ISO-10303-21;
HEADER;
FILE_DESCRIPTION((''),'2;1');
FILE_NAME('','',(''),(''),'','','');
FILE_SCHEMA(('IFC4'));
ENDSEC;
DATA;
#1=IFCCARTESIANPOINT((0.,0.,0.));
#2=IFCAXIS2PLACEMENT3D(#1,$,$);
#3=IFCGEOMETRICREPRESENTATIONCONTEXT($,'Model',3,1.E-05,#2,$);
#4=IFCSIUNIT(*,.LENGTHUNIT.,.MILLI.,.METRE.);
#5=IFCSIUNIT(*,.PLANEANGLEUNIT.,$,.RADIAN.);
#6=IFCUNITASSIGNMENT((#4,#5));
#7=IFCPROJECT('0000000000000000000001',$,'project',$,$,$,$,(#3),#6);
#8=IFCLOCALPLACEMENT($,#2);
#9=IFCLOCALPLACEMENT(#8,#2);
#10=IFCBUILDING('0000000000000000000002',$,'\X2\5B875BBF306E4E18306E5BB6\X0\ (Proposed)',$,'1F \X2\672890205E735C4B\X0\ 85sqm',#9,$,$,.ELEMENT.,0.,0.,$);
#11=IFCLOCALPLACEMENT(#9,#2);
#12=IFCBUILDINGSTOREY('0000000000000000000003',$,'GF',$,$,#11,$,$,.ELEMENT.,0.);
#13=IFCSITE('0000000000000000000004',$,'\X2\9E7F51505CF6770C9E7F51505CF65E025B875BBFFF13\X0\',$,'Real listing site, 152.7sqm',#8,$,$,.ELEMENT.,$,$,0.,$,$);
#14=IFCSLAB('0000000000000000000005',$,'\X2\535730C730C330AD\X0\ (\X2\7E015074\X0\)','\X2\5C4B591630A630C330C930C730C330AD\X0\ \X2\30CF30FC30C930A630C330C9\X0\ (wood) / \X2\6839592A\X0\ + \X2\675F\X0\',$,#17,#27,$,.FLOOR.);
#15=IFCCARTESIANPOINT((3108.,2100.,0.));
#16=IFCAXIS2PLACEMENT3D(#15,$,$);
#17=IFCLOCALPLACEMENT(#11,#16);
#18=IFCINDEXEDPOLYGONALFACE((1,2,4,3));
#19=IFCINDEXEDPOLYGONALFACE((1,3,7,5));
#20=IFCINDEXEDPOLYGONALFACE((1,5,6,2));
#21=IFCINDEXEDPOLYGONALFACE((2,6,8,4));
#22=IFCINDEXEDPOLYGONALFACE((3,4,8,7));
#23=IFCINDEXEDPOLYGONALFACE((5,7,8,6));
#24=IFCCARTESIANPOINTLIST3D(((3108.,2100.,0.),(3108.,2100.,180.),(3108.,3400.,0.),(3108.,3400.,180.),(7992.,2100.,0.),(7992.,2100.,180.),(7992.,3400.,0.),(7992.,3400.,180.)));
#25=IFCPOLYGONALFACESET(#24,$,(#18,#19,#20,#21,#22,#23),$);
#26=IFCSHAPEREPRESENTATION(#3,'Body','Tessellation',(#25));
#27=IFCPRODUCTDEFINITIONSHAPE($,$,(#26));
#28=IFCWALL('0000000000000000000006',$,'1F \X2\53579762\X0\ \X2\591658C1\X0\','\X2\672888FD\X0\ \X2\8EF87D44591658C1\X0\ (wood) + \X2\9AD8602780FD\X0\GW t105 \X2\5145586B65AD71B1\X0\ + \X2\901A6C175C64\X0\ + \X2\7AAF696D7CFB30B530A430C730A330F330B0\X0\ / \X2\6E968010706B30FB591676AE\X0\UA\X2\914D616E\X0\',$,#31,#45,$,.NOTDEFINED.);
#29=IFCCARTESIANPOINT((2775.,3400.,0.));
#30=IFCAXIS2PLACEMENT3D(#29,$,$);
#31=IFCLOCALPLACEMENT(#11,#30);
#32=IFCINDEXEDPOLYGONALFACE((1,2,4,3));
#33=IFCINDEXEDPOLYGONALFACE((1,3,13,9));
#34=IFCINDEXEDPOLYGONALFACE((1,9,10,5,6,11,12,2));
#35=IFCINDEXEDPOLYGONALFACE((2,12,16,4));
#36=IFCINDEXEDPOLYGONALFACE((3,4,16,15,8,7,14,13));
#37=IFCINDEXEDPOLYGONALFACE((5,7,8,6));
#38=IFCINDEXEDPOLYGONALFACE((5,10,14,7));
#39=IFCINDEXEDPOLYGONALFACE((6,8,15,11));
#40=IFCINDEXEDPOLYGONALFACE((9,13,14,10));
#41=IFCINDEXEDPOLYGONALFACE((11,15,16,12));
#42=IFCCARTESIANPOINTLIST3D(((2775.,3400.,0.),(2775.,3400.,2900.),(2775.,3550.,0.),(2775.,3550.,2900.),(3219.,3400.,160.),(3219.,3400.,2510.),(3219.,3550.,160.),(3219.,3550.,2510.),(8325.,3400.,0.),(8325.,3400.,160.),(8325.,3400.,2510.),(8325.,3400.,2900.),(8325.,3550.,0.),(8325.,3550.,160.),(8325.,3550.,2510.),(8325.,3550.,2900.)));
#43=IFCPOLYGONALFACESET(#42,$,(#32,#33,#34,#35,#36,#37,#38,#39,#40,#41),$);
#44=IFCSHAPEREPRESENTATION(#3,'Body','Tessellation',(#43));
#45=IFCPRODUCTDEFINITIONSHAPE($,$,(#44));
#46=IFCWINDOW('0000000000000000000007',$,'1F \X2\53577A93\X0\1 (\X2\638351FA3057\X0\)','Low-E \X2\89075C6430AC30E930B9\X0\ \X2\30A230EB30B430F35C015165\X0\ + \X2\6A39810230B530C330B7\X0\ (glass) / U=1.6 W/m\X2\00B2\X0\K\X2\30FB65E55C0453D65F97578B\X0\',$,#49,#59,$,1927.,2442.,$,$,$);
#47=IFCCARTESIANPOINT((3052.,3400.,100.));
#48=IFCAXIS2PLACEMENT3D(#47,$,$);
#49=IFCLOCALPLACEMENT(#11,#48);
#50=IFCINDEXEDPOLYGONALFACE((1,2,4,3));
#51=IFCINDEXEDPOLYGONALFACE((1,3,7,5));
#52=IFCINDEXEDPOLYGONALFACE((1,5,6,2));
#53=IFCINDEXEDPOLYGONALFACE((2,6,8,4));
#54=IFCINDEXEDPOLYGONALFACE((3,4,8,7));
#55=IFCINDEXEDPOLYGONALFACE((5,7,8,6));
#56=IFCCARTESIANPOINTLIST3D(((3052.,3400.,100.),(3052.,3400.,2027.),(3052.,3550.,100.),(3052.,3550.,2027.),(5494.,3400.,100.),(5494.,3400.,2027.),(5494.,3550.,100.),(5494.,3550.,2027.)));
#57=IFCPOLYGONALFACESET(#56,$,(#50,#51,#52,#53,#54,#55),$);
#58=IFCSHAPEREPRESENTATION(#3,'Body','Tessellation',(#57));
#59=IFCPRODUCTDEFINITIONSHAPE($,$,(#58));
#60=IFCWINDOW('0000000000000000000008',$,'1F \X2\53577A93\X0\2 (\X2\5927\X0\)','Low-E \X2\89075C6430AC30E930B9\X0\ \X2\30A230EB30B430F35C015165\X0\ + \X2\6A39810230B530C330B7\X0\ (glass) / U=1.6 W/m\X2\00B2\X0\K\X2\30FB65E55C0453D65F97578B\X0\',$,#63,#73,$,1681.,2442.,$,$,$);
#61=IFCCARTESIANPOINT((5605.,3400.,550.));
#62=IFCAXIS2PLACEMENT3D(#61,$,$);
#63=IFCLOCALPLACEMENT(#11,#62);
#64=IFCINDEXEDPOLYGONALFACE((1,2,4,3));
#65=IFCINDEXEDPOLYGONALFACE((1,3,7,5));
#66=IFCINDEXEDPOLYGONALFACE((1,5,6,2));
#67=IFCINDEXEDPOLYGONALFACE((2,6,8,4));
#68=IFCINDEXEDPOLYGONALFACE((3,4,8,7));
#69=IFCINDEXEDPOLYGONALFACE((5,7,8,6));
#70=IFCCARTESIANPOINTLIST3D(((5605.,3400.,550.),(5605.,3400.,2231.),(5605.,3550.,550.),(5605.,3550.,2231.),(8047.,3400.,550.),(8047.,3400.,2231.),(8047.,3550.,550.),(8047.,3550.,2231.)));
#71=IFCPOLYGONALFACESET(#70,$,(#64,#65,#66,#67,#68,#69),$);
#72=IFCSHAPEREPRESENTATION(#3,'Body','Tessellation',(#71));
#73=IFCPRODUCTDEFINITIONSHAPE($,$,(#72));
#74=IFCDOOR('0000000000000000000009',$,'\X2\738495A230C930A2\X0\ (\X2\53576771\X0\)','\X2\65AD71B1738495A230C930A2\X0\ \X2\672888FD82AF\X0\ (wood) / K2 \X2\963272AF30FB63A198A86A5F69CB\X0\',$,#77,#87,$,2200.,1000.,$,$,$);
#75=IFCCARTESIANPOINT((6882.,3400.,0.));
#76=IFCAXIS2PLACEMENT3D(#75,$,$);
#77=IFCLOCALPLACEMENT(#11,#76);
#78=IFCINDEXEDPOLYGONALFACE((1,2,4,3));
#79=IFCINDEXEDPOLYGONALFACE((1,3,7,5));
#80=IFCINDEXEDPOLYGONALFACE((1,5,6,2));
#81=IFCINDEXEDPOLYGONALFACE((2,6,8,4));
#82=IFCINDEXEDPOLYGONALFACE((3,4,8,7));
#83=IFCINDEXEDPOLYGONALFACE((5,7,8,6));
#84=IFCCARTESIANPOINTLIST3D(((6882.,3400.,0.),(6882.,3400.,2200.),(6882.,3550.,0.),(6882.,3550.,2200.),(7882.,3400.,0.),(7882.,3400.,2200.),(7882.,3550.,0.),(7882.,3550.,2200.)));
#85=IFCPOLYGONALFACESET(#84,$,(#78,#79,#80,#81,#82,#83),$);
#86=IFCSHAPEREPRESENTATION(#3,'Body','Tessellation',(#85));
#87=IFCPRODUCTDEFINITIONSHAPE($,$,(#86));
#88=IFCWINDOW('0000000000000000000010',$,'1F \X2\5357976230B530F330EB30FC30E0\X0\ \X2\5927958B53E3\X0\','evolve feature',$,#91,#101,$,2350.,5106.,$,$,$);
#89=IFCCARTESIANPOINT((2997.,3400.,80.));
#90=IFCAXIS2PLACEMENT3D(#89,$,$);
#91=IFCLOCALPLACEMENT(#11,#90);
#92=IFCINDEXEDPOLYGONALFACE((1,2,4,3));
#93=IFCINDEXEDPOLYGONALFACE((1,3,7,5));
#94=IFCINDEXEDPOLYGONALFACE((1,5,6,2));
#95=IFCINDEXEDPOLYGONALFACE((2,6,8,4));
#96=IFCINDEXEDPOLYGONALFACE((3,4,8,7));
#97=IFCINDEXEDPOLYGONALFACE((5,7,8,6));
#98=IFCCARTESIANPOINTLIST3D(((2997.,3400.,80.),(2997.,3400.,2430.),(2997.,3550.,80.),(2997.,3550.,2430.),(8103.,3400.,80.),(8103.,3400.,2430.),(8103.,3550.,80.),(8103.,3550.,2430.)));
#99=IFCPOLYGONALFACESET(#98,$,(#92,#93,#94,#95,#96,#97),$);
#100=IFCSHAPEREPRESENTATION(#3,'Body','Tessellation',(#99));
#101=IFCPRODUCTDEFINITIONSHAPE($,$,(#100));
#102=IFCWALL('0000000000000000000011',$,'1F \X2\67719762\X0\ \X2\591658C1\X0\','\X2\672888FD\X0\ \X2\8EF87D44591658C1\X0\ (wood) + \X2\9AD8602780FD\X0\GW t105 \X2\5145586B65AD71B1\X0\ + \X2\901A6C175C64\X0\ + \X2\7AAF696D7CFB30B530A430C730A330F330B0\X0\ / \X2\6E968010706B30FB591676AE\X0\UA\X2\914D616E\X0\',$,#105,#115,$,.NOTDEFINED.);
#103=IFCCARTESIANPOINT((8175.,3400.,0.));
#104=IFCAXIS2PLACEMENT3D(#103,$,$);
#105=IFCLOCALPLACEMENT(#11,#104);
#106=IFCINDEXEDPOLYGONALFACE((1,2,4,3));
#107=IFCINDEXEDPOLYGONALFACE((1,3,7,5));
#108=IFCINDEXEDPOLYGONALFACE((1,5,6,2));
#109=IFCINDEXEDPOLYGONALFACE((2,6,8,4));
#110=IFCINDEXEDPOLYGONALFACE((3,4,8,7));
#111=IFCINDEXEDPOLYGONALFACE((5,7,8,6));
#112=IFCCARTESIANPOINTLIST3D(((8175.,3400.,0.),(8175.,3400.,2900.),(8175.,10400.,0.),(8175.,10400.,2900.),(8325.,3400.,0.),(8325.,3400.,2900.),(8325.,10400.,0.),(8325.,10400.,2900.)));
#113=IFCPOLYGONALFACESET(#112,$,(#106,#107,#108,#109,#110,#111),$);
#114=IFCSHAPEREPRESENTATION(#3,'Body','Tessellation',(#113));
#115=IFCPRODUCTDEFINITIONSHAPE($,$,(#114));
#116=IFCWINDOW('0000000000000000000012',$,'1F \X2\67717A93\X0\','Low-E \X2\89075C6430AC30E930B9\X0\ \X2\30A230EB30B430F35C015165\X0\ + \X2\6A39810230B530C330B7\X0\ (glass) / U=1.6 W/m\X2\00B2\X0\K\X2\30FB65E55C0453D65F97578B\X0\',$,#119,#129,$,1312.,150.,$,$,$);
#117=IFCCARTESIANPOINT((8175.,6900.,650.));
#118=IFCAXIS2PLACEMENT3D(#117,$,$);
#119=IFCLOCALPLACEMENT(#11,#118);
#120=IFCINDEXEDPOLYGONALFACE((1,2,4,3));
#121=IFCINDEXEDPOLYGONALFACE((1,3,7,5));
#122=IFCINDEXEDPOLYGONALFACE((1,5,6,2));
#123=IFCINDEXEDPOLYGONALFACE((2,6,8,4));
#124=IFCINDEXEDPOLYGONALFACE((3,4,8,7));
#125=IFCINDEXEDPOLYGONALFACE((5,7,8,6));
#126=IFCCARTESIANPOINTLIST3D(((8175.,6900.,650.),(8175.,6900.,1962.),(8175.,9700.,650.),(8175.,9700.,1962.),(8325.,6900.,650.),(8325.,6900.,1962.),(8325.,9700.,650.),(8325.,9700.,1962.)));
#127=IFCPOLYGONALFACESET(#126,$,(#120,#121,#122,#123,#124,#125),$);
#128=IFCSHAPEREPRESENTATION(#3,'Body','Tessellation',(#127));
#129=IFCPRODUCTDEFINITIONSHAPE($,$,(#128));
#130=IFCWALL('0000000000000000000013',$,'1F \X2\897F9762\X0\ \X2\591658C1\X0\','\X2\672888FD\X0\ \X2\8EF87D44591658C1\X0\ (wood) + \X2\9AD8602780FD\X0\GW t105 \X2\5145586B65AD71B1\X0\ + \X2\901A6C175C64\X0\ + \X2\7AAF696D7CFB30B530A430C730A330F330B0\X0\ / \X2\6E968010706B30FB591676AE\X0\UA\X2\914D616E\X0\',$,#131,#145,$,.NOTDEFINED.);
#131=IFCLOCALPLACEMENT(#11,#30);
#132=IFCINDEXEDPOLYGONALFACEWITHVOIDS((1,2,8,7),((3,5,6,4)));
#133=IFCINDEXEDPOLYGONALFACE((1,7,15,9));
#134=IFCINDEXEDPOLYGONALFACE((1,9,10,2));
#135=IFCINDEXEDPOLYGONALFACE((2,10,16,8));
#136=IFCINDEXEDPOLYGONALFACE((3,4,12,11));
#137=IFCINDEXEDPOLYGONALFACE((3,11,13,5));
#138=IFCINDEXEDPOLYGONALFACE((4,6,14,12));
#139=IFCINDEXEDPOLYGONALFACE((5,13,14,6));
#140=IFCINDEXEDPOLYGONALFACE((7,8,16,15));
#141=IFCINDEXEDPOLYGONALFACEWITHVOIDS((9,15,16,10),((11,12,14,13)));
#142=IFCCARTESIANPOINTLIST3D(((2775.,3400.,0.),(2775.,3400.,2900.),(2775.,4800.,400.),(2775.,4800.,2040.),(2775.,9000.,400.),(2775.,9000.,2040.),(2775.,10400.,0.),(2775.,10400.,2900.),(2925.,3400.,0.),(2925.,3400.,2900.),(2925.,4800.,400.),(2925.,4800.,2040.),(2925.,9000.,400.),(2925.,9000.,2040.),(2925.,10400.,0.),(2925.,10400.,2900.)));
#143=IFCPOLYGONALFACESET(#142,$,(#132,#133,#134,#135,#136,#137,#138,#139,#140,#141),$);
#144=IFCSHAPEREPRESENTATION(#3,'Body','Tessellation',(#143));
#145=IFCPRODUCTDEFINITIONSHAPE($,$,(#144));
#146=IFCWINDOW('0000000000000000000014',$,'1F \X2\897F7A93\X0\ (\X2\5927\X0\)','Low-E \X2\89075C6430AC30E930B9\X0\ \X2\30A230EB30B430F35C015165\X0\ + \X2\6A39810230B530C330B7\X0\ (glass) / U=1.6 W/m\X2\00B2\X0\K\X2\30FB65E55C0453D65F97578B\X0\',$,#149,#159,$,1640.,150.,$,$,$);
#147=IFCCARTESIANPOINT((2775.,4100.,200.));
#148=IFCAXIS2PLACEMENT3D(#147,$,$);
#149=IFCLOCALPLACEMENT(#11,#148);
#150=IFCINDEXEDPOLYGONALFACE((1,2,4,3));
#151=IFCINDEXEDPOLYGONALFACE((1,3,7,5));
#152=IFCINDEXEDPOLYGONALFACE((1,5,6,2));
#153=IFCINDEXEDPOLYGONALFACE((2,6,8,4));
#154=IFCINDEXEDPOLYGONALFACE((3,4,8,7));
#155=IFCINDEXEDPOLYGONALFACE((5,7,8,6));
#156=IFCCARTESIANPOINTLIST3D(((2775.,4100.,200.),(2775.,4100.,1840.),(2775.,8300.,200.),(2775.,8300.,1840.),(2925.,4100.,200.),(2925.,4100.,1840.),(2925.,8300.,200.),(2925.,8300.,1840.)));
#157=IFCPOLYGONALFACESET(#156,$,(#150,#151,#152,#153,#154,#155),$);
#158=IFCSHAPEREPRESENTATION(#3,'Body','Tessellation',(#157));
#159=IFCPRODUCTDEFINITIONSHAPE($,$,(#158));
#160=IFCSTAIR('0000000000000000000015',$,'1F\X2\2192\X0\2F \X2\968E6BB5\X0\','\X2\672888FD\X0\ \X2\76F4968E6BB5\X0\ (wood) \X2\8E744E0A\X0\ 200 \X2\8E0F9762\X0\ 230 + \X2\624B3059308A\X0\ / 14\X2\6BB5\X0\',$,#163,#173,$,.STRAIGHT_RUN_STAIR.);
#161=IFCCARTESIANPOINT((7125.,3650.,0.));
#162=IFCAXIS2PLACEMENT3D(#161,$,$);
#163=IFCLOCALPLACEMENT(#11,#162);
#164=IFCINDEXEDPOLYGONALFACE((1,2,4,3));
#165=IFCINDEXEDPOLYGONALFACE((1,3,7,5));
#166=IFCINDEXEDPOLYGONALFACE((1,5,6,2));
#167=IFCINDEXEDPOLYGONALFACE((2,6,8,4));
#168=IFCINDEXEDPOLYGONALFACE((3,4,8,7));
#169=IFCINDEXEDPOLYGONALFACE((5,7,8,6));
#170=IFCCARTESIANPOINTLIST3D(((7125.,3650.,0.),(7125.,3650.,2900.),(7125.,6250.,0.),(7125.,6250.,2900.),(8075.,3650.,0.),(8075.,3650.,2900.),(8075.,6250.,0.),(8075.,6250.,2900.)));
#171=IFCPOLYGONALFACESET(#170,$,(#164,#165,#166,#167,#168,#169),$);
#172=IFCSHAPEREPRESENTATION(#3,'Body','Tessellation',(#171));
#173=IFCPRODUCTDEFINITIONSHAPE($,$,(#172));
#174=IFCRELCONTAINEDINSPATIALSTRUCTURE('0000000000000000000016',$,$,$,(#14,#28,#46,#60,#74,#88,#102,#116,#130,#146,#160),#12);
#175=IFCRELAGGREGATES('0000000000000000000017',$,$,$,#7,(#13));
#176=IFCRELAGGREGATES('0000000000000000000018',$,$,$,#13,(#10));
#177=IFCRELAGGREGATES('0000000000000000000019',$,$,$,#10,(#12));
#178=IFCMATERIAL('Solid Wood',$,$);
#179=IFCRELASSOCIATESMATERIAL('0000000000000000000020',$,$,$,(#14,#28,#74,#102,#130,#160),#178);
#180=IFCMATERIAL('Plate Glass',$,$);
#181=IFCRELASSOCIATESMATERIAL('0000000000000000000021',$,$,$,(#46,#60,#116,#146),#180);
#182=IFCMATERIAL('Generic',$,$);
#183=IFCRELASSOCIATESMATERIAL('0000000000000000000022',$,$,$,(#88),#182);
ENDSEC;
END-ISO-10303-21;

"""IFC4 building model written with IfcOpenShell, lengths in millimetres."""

from ifc_helpers import new_model, si_unit, frame, frame_2d, origin, place, context, project, spatial, rectangle, extrude, material, element, fill, save


model = new_model("IFC4")

# Units and contexts
model_context = context("Model", 3, precision=1e-05, world=origin())
ifc_project = project(units=[si_unit("LENGTHUNIT", "METRE", prefix="MILLI"), si_unit("PLANEANGLEUNIT", "RADIAN")], contexts=[model_context])

# Site, building, storey
site_placement = place(None, origin())
site = spatial("IfcSite", under=ifc_project, at=site_placement, Name="鹿児島県鹿児島市宇宿３", ObjectType="Real listing site, 152.7sqm", CompositionType="ELEMENT", RefElevation=0.0)
building_placement = place(site_placement, origin())
building = spatial("IfcBuilding", under=site, at=building_placement, Name="宇宿の丘の家 (Proposed)", ObjectType="1F 木造平屋 85sqm", CompositionType="ELEMENT", ElevationOfRefHeight=0.0, ElevationOfTerrain=0.0)
storey_placement = place(building_placement, origin())
storey = spatial("IfcBuildingStorey", under=building, at=storey_placement, Name="GF", CompositionType="ELEMENT", Elevation=0.0)

# Slab
ifc_material_1 = material(Name="Solid Wood")
slab_1_placement = place(storey_placement, frame((3108.0, 2100.0, 0.0)))
element("IfcSlab", 1, at=slab_1_placement, inside=storey, material=ifc_material_1, Name="南デッキ (縁側)", Description="屋外ウッドデッキ ハードウッド (wood) / 根太 + 束", PredefinedType="FLOOR", context=model_context, shape_type="SweptSolid", body=[
    extrude(rectangle(XDim=4884.0, YDim=1300.0, at=frame_2d((2442.0, 650.0))), frame((3108.0, 2100.0, 0.0)), (0.0, 0.0, 1.0), 180.0),
])
ifc_material_2 = material(Name="Generic")

# Wall, openings, windows, door
wall_1_placement = place(storey_placement, frame((2775.0, 3400.0, 0.0)))
wall_1 = element("IfcWall", 2, at=wall_1_placement, inside=storey, material=ifc_material_1, Name="1F 南面 外壁", Description="木製 軸組外壁 (wood) + 高性能GW t105 充填断熱 + 通気層 + 窯業系サイディング / 準耐火・外皮UA配慮", PredefinedType="NOTDEFINED", context=model_context, shape_type="SweptSolid", body=[
    extrude(rectangle(XDim=5550.0, YDim=150.0, at=frame_2d((2775.0, 75.0))), frame((2775.0, 3400.0, 0.0)), (0.0, 0.0, 1.0), 2900.0),
])
opening_1_placement = place(storey_placement, frame((3052.0, 3400.0, 100.0)))
opening_1 = element("IfcOpeningElement", 3, at=opening_1_placement, cuts=wall_1, PredefinedType="NOTDEFINED", context=model_context, shape_type="SweptSolid", body=[
    extrude(rectangle(XDim=2442.0, YDim=150.0, at=frame_2d((1221.0, 75.0))), frame((3052.0, 3400.0, 100.0)), (0.0, 0.0, 1.0), 1927.0),
])
opening_2_placement = place(storey_placement, frame((5605.0, 3400.0, 550.0)))
opening_2 = element("IfcOpeningElement", 4, at=opening_2_placement, cuts=wall_1, PredefinedType="NOTDEFINED", context=model_context, shape_type="SweptSolid", body=[
    extrude(rectangle(XDim=2442.0, YDim=150.0, at=frame_2d((1221.0, 75.0))), frame((5605.0, 3400.0, 550.0)), (0.0, 0.0, 1.0), 1681.0),
])
opening_3_placement = place(storey_placement, frame((6882.0, 3400.0, 0.0)))
opening_3 = element("IfcOpeningElement", 5, at=opening_3_placement, cuts=wall_1, PredefinedType="NOTDEFINED", context=model_context, shape_type="SweptSolid", body=[
    extrude(rectangle(XDim=1000.0, YDim=150.0, at=frame_2d((500.0, 75.0))), frame((6882.0, 3400.0, 0.0)), (0.0, 0.0, 1.0), 2200.0),
])
opening_4_placement = place(storey_placement, frame((2997.0, 3400.0, 80.0)))
opening_4 = element("IfcOpeningElement", 6, at=opening_4_placement, cuts=wall_1, PredefinedType="NOTDEFINED", context=model_context, shape_type="SweptSolid", body=[
    extrude(rectangle(XDim=5106.0, YDim=150.0, at=frame_2d((2553.0, 75.0))), frame((2997.0, 3400.0, 80.0)), (0.0, 0.0, 1.0), 2350.0),
])
ifc_material_3 = material(Name="Plate Glass")
window_1_placement = place(storey_placement, frame((3052.0, 3400.0, 100.0)))
window_1 = element("IfcWindow", 7, at=window_1_placement, inside=storey, material=ifc_material_3, Name="1F 南窓1 (掃出し)", Description="Low-E 複層ガラス アルゴン封入 + 樹脂サッシ (glass) / U=1.6 W/m²K・日射取得型", OverallHeight=1927.0, OverallWidth=2442.0, context=model_context, shape_type="SweptSolid", body=[
    extrude(rectangle(XDim=2442.0, YDim=150.0, at=frame_2d((1221.0, 75.0))), frame((3052.0, 3400.0, 100.0)), (0.0, 0.0, 1.0), 1927.0),
])
fill(opening_1, window_1)
window_2_placement = place(storey_placement, frame((5605.0, 3400.0, 550.0)))
window_2 = element("IfcWindow", 8, at=window_2_placement, inside=storey, material=ifc_material_3, Name="1F 南窓2 (大)", Description="Low-E 複層ガラス アルゴン封入 + 樹脂サッシ (glass) / U=1.6 W/m²K・日射取得型", OverallHeight=1681.0, OverallWidth=2442.0, context=model_context, shape_type="SweptSolid", body=[
    extrude(rectangle(XDim=2442.0, YDim=150.0, at=frame_2d((1221.0, 75.0))), frame((5605.0, 3400.0, 550.0)), (0.0, 0.0, 1.0), 1681.0),
])
fill(opening_2, window_2)
door_placement = place(storey_placement, frame((6882.0, 3400.0, 0.0)))
door = element("IfcDoor", 9, at=door_placement, inside=storey, material=ifc_material_1, Name="玄関ドア (南東)", Description="断熱玄関ドア 木製芯 (wood) / K2 防犯・採風機構", OverallHeight=2200.0, OverallWidth=1000.0, context=model_context, shape_type="SweptSolid", body=[
    extrude(rectangle(XDim=1000.0, YDim=150.0, at=frame_2d((500.0, 75.0))), frame((6882.0, 3400.0, 0.0)), (0.0, 0.0, 1.0), 2200.0),
])
fill(opening_3, door)
window_3_placement = place(storey_placement, frame((2997.0, 3400.0, 80.0)))
window_3 = element("IfcWindow", 10, at=window_3_placement, inside=storey, material=ifc_material_2, Name="1F 南面サンルーム 大開口", Description="evolve feature", OverallHeight=2350.0, OverallWidth=5106.0, context=model_context, shape_type="SweptSolid", body=[
    extrude(rectangle(XDim=5106.0, YDim=150.0, at=frame_2d((2553.0, 75.0))), frame((2997.0, 3400.0, 80.0)), (0.0, 0.0, 1.0), 2350.0),
])
fill(opening_4, window_3)

# Walls, openings, windows
wall_2_placement = place(storey_placement, frame((8175.0, 3400.0, 0.0)))
wall_2 = element("IfcWall", 11, at=wall_2_placement, inside=storey, material=ifc_material_1, Name="1F 東面 外壁", Description="木製 軸組外壁 (wood) + 高性能GW t105 充填断熱 + 通気層 + 窯業系サイディング / 準耐火・外皮UA配慮", PredefinedType="NOTDEFINED", context=model_context, shape_type="SweptSolid", body=[
    extrude(rectangle(XDim=150.0, YDim=7000.0, at=frame_2d((75.0, 3500.0))), frame((8175.0, 3400.0, 0.0)), (0.0, 0.0, 1.0), 2900.0),
])
opening_5_placement = place(storey_placement, frame((8175.0, 6900.0, 650.0)))
opening_5 = element("IfcOpeningElement", 12, at=opening_5_placement, cuts=wall_2, PredefinedType="NOTDEFINED", context=model_context, shape_type="SweptSolid", body=[
    extrude(rectangle(XDim=150.0, YDim=2800.0, at=frame_2d((75.0, 1400.0))), frame((8175.0, 6900.0, 650.0)), (0.0, 0.0, 1.0), 1312.0),
])
window_4_placement = place(storey_placement, frame((8175.0, 6900.0, 650.0)))
window_4 = element("IfcWindow", 13, at=window_4_placement, inside=storey, material=ifc_material_3, Name="1F 東窓", Description="Low-E 複層ガラス アルゴン封入 + 樹脂サッシ (glass) / U=1.6 W/m²K・日射取得型", OverallHeight=1312.0, OverallWidth=150.0, context=model_context, shape_type="SweptSolid", body=[
    extrude(rectangle(XDim=150.0, YDim=2800.0, at=frame_2d((75.0, 1400.0))), frame((8175.0, 6900.0, 650.0)), (0.0, 0.0, 1.0), 1312.0),
])
fill(opening_5, window_4)
wall_3_placement = place(storey_placement, frame((2775.0, 3400.0, 0.0)))
wall_3 = element("IfcWall", 14, at=wall_3_placement, inside=storey, material=ifc_material_1, Name="1F 西面 外壁", Description="木製 軸組外壁 (wood) + 高性能GW t105 充填断熱 + 通気層 + 窯業系サイディング / 準耐火・外皮UA配慮", PredefinedType="NOTDEFINED", context=model_context, shape_type="SweptSolid", body=[
    extrude(rectangle(XDim=150.0, YDim=7000.0, at=frame_2d((75.0, 3500.0))), frame((2775.0, 3400.0, 0.0)), (0.0, 0.0, 1.0), 2900.0),
])
opening_6_placement = place(storey_placement, frame((2775.0, 4100.0, 200.0)))
opening_6 = element("IfcOpeningElement", 15, at=opening_6_placement, cuts=wall_3, PredefinedType="NOTDEFINED", context=model_context, shape_type="SweptSolid", body=[
    extrude(rectangle(XDim=150.0, YDim=4200.0, at=frame_2d((75.0, 2100.0))), frame((2775.0, 4100.0, 200.0)), (0.0, 0.0, 1.0), 1640.0),
])
window_5_placement = place(storey_placement, frame((2775.0, 4100.0, 200.0)))
window_5 = element("IfcWindow", 16, at=window_5_placement, inside=storey, material=ifc_material_3, Name="1F 西窓 (大)", Description="Low-E 複層ガラス アルゴン封入 + 樹脂サッシ (glass) / U=1.6 W/m²K・日射取得型", OverallHeight=1640.0, OverallWidth=150.0, context=model_context, shape_type="SweptSolid", body=[
    extrude(rectangle(XDim=150.0, YDim=4200.0, at=frame_2d((75.0, 2100.0))), frame((2775.0, 4100.0, 200.0)), (0.0, 0.0, 1.0), 1640.0),
])
fill(opening_6, window_5)

# Stair
stair_placement = place(storey_placement, frame((7125.0, 3650.0, 0.0)))
element("IfcStair", 17, at=stair_placement, inside=storey, material=ifc_material_1, Name="1F→2F 階段", Description="木製 直階段 (wood) 蹴上 200 踏面 230 + 手すり / 14段", PredefinedType="STRAIGHT_RUN_STAIR", context=model_context, shape_type="SweptSolid", body=[
    extrude(rectangle(XDim=950.0, YDim=2600.0, at=frame_2d((475.0, 1300.0))), frame((7125.0, 3650.0, 0.0)), (0.0, 0.0, 1.0), 2900.0),
])

save(model, "model.ifc")
